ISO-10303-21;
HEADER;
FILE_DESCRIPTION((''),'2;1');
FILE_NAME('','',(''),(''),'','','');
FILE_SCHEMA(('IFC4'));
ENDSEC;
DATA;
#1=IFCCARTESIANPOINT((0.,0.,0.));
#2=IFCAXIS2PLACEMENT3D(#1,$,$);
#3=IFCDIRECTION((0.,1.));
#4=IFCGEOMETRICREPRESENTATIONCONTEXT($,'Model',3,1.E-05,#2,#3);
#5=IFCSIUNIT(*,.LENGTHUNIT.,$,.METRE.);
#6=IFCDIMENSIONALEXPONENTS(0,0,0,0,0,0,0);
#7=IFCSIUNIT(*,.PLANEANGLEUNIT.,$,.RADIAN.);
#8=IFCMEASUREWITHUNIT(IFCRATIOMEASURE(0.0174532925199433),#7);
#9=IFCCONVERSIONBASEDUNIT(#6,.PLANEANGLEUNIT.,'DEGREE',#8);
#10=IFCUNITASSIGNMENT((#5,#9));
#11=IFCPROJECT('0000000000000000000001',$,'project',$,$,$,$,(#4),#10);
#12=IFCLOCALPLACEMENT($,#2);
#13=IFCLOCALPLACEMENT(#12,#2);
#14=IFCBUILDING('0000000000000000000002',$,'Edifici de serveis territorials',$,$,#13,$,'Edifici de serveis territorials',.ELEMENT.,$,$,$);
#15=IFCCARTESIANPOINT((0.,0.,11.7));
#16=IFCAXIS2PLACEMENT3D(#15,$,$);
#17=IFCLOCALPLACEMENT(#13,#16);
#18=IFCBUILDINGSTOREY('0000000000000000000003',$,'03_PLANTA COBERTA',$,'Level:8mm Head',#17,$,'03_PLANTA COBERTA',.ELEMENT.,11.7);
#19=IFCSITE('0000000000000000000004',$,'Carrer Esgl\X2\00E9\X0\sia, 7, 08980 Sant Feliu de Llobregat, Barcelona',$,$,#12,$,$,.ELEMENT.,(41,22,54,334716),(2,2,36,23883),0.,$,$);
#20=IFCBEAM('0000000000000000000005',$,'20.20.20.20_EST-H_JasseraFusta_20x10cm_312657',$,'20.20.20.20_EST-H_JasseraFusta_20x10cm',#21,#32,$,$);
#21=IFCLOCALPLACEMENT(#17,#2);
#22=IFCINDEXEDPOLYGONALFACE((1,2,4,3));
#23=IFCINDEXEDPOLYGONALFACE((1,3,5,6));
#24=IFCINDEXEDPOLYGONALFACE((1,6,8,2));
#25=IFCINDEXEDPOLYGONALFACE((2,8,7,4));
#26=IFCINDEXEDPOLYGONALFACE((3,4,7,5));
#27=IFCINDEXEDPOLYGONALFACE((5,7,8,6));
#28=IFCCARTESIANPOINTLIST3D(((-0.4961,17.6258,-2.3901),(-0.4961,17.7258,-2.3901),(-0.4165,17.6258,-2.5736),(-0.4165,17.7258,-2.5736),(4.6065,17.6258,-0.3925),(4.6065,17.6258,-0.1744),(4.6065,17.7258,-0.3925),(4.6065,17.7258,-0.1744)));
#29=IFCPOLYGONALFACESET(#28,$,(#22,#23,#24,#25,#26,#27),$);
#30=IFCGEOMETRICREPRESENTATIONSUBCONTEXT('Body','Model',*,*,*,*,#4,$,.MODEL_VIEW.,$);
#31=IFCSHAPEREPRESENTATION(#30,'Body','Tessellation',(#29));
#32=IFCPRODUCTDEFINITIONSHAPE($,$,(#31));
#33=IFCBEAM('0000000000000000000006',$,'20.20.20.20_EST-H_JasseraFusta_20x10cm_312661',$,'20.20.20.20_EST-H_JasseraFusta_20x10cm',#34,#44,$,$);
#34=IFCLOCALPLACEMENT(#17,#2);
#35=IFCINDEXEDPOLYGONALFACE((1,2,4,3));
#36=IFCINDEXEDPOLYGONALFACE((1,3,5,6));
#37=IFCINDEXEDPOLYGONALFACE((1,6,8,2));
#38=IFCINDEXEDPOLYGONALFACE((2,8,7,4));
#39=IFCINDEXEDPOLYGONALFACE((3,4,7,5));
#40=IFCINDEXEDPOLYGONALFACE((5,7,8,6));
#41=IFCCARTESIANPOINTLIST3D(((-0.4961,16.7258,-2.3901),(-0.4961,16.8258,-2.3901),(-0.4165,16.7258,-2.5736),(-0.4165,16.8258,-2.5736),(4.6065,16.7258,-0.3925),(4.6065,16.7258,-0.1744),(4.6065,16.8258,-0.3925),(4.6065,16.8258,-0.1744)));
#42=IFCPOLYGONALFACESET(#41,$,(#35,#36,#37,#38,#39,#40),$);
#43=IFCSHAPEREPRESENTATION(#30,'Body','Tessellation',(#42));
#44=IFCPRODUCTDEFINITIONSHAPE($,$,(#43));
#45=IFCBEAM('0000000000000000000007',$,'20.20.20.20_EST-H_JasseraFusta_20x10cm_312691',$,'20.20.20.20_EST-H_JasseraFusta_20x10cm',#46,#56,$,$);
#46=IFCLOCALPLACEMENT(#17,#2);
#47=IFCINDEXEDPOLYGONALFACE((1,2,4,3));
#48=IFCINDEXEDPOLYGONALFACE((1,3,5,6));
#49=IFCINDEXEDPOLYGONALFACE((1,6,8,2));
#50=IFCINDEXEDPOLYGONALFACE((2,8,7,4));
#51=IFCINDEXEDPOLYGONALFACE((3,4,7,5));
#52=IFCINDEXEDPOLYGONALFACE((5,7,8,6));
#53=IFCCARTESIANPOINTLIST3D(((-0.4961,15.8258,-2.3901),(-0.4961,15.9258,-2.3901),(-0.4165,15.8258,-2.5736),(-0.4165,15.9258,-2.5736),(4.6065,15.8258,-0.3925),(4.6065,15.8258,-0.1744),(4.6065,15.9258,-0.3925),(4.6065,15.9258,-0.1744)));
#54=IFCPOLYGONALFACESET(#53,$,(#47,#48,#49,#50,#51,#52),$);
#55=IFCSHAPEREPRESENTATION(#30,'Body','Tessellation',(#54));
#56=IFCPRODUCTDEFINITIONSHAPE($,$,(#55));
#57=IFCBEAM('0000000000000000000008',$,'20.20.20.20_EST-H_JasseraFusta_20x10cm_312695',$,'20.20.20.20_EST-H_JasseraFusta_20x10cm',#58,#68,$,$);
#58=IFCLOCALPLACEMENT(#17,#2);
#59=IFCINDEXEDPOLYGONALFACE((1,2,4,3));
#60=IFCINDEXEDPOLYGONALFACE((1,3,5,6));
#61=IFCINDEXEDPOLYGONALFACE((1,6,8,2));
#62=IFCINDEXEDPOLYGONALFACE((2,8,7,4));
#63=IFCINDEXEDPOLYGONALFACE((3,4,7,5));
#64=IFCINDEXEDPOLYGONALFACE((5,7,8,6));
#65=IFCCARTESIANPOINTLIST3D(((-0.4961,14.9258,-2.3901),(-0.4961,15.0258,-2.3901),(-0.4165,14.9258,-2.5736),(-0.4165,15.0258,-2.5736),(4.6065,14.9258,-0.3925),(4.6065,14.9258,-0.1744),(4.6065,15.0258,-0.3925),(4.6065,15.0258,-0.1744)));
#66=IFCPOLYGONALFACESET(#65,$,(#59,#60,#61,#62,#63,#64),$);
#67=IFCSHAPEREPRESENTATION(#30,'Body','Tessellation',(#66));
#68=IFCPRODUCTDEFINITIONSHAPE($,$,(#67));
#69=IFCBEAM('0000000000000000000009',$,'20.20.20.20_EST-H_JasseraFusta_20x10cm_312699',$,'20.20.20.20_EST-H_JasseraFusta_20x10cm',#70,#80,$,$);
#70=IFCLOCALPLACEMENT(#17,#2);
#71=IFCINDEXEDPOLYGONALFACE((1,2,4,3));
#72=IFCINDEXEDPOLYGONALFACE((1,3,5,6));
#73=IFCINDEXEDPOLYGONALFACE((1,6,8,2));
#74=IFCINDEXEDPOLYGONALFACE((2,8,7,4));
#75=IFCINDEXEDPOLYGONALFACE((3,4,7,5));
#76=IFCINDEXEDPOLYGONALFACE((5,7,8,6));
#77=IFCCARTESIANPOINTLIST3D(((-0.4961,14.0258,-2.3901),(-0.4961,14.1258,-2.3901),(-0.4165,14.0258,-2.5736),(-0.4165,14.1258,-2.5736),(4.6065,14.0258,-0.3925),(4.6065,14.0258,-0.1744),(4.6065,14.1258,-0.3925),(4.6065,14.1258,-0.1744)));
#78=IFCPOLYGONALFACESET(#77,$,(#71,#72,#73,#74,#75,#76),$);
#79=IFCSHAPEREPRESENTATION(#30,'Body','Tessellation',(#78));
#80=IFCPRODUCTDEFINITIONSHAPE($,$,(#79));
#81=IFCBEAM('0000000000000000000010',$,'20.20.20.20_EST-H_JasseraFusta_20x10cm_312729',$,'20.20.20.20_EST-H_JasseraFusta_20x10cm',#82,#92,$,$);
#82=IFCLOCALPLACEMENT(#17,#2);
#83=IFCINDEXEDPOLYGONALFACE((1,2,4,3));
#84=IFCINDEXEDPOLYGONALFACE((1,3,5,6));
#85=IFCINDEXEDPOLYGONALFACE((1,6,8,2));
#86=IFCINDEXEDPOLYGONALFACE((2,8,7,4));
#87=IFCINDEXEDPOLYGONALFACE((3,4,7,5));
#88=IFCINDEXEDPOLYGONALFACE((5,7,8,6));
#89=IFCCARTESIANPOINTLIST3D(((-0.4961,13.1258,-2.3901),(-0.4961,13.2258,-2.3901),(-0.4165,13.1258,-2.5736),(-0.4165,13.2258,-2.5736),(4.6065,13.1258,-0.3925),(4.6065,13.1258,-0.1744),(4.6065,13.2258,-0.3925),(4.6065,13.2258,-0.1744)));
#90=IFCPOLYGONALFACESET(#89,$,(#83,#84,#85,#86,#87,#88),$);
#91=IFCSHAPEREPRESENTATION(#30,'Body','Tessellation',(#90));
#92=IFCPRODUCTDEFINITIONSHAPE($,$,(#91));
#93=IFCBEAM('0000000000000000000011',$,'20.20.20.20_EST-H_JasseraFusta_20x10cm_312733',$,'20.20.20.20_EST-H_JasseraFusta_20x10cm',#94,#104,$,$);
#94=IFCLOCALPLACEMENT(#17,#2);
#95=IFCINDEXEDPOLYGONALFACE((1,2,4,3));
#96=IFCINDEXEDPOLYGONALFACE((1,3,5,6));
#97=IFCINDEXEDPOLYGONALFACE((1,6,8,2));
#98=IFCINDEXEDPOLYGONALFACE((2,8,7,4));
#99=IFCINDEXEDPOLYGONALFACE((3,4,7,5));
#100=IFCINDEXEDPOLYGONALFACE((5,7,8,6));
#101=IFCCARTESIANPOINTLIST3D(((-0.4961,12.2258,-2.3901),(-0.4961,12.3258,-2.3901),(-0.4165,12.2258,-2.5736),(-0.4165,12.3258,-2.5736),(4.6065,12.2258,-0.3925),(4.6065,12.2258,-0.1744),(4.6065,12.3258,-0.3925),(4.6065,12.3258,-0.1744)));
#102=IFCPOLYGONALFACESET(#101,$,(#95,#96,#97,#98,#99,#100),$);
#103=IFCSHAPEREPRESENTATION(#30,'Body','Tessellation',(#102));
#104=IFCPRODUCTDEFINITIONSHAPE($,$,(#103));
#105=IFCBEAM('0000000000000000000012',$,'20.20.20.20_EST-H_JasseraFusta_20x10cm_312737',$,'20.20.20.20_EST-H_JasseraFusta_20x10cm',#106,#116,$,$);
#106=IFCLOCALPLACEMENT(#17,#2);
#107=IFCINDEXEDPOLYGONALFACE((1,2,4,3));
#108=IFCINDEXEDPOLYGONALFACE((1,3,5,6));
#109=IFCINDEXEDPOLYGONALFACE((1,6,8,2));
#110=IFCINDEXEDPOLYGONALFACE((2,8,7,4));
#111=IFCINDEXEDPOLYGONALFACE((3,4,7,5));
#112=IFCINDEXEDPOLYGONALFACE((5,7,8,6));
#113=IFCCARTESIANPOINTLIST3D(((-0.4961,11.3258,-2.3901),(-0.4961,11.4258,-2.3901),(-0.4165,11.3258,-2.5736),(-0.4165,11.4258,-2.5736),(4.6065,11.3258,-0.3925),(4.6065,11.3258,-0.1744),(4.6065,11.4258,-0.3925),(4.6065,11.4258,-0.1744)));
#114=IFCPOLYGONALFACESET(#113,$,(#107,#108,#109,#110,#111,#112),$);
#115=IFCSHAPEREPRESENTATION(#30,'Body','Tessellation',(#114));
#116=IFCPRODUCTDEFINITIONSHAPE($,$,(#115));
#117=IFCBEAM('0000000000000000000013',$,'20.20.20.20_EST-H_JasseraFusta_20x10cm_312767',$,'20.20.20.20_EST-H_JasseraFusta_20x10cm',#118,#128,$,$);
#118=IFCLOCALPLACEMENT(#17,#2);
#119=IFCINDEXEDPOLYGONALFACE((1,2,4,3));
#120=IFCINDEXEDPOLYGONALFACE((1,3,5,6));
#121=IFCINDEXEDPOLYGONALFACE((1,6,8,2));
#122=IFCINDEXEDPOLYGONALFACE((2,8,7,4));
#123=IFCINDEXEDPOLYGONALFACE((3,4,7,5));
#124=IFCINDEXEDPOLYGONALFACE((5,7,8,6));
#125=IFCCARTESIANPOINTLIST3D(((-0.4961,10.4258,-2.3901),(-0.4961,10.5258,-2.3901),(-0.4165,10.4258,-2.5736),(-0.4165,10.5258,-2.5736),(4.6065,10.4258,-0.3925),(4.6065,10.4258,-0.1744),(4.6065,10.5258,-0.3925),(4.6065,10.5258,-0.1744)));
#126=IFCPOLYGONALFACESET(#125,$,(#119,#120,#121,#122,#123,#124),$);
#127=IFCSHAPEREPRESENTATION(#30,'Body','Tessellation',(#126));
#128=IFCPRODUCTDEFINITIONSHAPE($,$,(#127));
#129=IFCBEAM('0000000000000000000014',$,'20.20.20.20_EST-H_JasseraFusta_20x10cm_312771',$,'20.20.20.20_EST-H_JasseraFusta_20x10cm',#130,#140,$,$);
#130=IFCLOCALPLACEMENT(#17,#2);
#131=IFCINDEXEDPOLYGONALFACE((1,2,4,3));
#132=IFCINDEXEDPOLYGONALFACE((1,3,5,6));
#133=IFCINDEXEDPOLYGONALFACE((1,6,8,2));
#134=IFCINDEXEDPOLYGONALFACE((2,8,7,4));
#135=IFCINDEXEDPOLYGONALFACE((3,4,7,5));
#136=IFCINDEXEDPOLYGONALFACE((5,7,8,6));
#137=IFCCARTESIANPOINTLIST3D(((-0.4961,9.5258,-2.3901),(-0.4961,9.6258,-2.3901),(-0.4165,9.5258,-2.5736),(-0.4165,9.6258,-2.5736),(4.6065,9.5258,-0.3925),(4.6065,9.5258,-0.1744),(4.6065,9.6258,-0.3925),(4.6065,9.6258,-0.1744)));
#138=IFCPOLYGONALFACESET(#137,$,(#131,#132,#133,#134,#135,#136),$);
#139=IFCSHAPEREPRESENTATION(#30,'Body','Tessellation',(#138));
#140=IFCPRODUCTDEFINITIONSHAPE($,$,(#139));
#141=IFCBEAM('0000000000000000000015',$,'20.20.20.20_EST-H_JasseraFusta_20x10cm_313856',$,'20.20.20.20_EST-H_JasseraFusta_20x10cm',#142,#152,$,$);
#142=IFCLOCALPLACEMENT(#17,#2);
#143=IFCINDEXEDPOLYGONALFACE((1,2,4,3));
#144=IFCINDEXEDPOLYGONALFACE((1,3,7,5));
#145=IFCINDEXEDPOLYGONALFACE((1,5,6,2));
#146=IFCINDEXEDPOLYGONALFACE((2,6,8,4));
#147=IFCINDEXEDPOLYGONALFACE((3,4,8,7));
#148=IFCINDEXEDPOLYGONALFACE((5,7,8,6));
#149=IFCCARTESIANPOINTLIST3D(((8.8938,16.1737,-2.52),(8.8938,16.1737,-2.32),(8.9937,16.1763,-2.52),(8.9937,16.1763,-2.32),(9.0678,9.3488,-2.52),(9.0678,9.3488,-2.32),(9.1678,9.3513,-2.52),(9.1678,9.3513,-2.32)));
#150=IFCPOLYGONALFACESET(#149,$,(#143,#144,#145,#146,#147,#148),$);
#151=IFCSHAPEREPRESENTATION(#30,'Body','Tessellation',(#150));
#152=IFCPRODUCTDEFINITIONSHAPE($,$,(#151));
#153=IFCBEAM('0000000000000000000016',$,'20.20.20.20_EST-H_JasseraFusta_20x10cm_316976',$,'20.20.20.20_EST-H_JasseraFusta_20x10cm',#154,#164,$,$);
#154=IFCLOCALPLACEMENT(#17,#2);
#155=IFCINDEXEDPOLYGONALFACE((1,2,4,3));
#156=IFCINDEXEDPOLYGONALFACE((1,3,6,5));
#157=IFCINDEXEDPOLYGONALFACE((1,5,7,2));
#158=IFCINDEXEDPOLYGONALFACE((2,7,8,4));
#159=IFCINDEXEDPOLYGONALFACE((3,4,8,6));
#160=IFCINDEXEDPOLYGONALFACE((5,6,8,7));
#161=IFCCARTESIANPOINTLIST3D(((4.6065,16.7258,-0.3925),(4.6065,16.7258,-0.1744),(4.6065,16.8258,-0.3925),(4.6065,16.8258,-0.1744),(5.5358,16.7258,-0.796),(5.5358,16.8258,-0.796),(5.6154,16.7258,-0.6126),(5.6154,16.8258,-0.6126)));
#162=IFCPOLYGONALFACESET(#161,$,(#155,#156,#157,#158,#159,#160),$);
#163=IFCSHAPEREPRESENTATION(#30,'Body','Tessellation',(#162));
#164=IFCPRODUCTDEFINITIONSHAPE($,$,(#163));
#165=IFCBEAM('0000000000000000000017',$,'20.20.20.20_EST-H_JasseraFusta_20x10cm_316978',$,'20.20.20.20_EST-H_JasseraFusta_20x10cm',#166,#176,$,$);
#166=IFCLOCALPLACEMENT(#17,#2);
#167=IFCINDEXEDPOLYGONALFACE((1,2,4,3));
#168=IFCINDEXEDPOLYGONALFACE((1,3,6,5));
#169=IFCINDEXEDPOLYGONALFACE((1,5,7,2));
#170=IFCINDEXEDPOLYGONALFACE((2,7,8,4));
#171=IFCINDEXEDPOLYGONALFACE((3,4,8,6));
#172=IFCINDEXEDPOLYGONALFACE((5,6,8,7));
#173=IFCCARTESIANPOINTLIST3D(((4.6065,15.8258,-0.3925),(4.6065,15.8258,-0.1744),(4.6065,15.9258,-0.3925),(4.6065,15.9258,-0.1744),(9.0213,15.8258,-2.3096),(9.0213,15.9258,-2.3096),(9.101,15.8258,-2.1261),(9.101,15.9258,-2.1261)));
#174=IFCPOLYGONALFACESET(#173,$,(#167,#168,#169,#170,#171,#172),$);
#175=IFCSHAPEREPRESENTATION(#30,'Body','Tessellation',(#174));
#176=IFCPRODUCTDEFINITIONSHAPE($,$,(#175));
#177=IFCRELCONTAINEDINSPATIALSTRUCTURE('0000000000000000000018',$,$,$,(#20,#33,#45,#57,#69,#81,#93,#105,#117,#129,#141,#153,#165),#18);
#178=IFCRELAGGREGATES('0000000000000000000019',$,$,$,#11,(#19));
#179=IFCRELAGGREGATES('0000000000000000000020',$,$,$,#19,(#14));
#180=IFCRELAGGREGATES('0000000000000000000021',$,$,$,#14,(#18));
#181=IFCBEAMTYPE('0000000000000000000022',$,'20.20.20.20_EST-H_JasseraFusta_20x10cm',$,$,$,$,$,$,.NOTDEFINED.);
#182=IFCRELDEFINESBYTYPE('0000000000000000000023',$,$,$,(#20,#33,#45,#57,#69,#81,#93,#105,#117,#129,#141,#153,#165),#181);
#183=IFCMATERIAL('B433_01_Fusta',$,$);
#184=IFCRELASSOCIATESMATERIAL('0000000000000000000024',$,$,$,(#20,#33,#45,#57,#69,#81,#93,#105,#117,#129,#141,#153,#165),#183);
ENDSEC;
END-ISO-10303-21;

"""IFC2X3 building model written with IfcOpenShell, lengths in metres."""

from ifc_helpers import new_model, entity, si_unit, converted_unit, direction, frame, frame_2d, origin, place, context, subcontext, project, spatial, rectangle, extrude, clip, halfspace, material, type_object, element, save


model = new_model("IFC2X3")

# Units and contexts
model_context = context("Model", 3, precision=1e-05, world=origin(), true_north=direction((0.0, 1.0)))
body_context = subcontext(model_context, "Body", "Model", "MODEL_VIEW")
ifc_project = project(units=[si_unit("LENGTHUNIT", "METRE"), converted_unit("PLANEANGLEUNIT", "DEGREE", entity("IfcRatioMeasure", 0.0174532925199433), si_unit("PLANEANGLEUNIT", "RADIAN"), dimensions=[0, 0, 0, 0, 0, 0, 0])], contexts=[model_context])

# Site, building, storey
site_placement = place(None, origin())
site = spatial("IfcSite", under=ifc_project, at=site_placement, Name="Carrer Església, 7, 08980 Sant Feliu de Llobregat, Barcelona", CompositionType="ELEMENT", RefLatitude=(41, 22, 54, 334716), RefLongitude=(2, 2, 36, 23883), RefElevation=0.0)
building_placement = place(site_placement, origin())
building = spatial("IfcBuilding", under=site, at=building_placement, Name="Edifici de serveis territorials", LongName="Edifici de serveis territorials", CompositionType="ELEMENT")
storey_placement = place(building_placement, frame((0.0, 0.0, 11.7)))
storey = spatial("IfcBuildingStorey", under=building, at=storey_placement, Name="03_PLANTA COBERTA", ObjectType="Level:8mm Head", LongName="03_PLANTA COBERTA", CompositionType="ELEMENT", Elevation=11.7)

# Beams
ifc_material_1 = material(Name="B433_01_Fusta")
beam_type = type_object("IfcBeamType", Name="20.20.20.20_EST-H_JasseraFusta_20x10cm", PredefinedType="NOTDEFINED")
beam_1_placement = place(storey_placement, frame((4.6065, 17.6758, -0.1744), z_axis=(-0.3983, 0.0, 0.917255), x_axis=(-0.917255, 0.0, -0.3983)))
element("IfcBeam", 1, at=beam_1_placement, inside=storey, type_object=beam_type, material=ifc_material_1, Name="20.20.20.20_EST-H_JasseraFusta_20x10cm_312657", ObjectType="20.20.20.20_EST-H_JasseraFusta_20x10cm", context=body_context, shape_type="Clipping", body=[
    clip(extrude(rectangle(XDim=0.2, YDim=0.1, at=frame_2d((0.0, 0.0), x_axis=(1.0, 0.0))), frame((0.0, 0.0, -0.1), z_axis=(1.0, 0.0, 0.0), x_axis=(0.0, 0.0, -1.0)), (0.0, 0.0, 1.0), 5.5629), halfspace(frame((0.0868, 0.0, -0.2), z_axis=(-0.917255, 0.0, -0.3983), x_axis=(0.0, 1.0, 0.0)), False)),
])
beam_2_placement = place(storey_placement, frame((4.6065, 16.7758, -0.1744), z_axis=(-0.3983, 0.0, 0.917255), x_axis=(-0.917255, 0.0, -0.3983)))
element("IfcBeam", 2, at=beam_2_placement, inside=storey, type_object=beam_type, material=ifc_material_1, Name="20.20.20.20_EST-H_JasseraFusta_20x10cm_312661", ObjectType="20.20.20.20_EST-H_JasseraFusta_20x10cm", context=body_context, shape_type="Clipping", body=[
    clip(extrude(rectangle(XDim=0.2, YDim=0.1, at=frame_2d((0.0, 0.0), x_axis=(1.0, 0.0))), frame((0.0, 0.0, -0.1), z_axis=(1.0, 0.0, 0.0), x_axis=(0.0, 0.0, -1.0)), (0.0, 0.0, 1.0), 5.5629), halfspace(frame((0.0868, 0.0, -0.2), z_axis=(-0.917255, 0.0, -0.3983), x_axis=(0.0, 1.0, 0.0)), False)),
])
beam_3_placement = place(storey_placement, frame((4.6065, 15.8758, -0.1744), z_axis=(-0.3983, 0.0, 0.917255), x_axis=(-0.917255, 0.0, -0.3983)))
element("IfcBeam", 3, at=beam_3_placement, inside=storey, type_object=beam_type, material=ifc_material_1, Name="20.20.20.20_EST-H_JasseraFusta_20x10cm_312691", ObjectType="20.20.20.20_EST-H_JasseraFusta_20x10cm", context=body_context, shape_type="Clipping", body=[
    clip(extrude(rectangle(XDim=0.2, YDim=0.1, at=frame_2d((0.0, 0.0), x_axis=(1.0, 0.0))), frame((0.0, 0.0, -0.1), z_axis=(1.0, 0.0, 0.0), x_axis=(0.0, 0.0, -1.0)), (0.0, 0.0, 1.0), 5.5629), halfspace(frame((0.0868, 0.0, -0.2), z_axis=(-0.917255, 0.0, -0.3983), x_axis=(0.0, 1.0, 0.0)), False)),
])
beam_4_placement = place(storey_placement, frame((4.6065, 14.9758, -0.1744), z_axis=(-0.3983, 0.0, 0.917255), x_axis=(-0.917255, 0.0, -0.3983)))
element("IfcBeam", 4, at=beam_4_placement, inside=storey, type_object=beam_type, material=ifc_material_1, Name="20.20.20.20_EST-H_JasseraFusta_20x10cm_312695", ObjectType="20.20.20.20_EST-H_JasseraFusta_20x10cm", context=body_context, shape_type="Clipping", body=[
    clip(extrude(rectangle(XDim=0.2, YDim=0.1, at=frame_2d((0.0, 0.0), x_axis=(1.0, 0.0))), frame((0.0, 0.0, -0.1), z_axis=(1.0, 0.0, 0.0), x_axis=(0.0, 0.0, -1.0)), (0.0, 0.0, 1.0), 5.5629), halfspace(frame((0.0868, 0.0, -0.2), z_axis=(-0.917255, 0.0, -0.3983), x_axis=(0.0, 1.0, 0.0)), False)),
])
beam_5_placement = place(storey_placement, frame((4.6065, 14.0758, -0.1744), z_axis=(-0.3983, 0.0, 0.917255), x_axis=(-0.917255, 0.0, -0.3983)))
element("IfcBeam", 5, at=beam_5_placement, inside=storey, type_object=beam_type, material=ifc_material_1, Name="20.20.20.20_EST-H_JasseraFusta_20x10cm_312699", ObjectType="20.20.20.20_EST-H_JasseraFusta_20x10cm", context=body_context, shape_type="Clipping", body=[
    clip(extrude(rectangle(XDim=0.2, YDim=0.1, at=frame_2d((0.0, 0.0), x_axis=(1.0, 0.0))), frame((0.0, 0.0, -0.1), z_axis=(1.0, 0.0, 0.0), x_axis=(0.0, 0.0, -1.0)), (0.0, 0.0, 1.0), 5.5629), halfspace(frame((0.0868, 0.0, -0.2), z_axis=(-0.917255, 0.0, -0.3983), x_axis=(0.0, 1.0, 0.0)), False)),
])
beam_6_placement = place(storey_placement, frame((4.6065, 13.1758, -0.1744), z_axis=(-0.3983, 0.0, 0.917255), x_axis=(-0.917255, 0.0, -0.3983)))
element("IfcBeam", 6, at=beam_6_placement, inside=storey, type_object=beam_type, material=ifc_material_1, Name="20.20.20.20_EST-H_JasseraFusta_20x10cm_312729", ObjectType="20.20.20.20_EST-H_JasseraFusta_20x10cm", context=body_context, shape_type="Clipping", body=[
    clip(extrude(rectangle(XDim=0.2, YDim=0.1, at=frame_2d((0.0, 0.0), x_axis=(1.0, 0.0))), frame((0.0, 0.0, -0.1), z_axis=(1.0, 0.0, 0.0), x_axis=(0.0, 0.0, -1.0)), (0.0, 0.0, 1.0), 5.5629), halfspace(frame((0.0868, 0.0, -0.2), z_axis=(-0.917255, 0.0, -0.3983), x_axis=(0.0, 1.0, 0.0)), False)),
])
beam_7_placement = place(storey_placement, frame((4.6065, 12.2758, -0.1744), z_axis=(-0.3983, 0.0, 0.917255), x_axis=(-0.917255, 0.0, -0.3983)))
element("IfcBeam", 7, at=beam_7_placement, inside=storey, type_object=beam_type, material=ifc_material_1, Name="20.20.20.20_EST-H_JasseraFusta_20x10cm_312733", ObjectType="20.20.20.20_EST-H_JasseraFusta_20x10cm", context=body_context, shape_type="Clipping", body=[
    clip(extrude(rectangle(XDim=0.2, YDim=0.1, at=frame_2d((0.0, 0.0), x_axis=(1.0, 0.0))), frame((0.0, 0.0, -0.1), z_axis=(1.0, 0.0, 0.0), x_axis=(0.0, 0.0, -1.0)), (0.0, 0.0, 1.0), 5.5629), halfspace(frame((0.0868, 0.0, -0.2), z_axis=(-0.917255, 0.0, -0.3983), x_axis=(0.0, 1.0, 0.0)), False)),
])
beam_8_placement = place(storey_placement, frame((4.6065, 11.3758, -0.1744), z_axis=(-0.3983, 0.0, 0.917255), x_axis=(-0.917255, 0.0, -0.3983)))
element("IfcBeam", 8, at=beam_8_placement, inside=storey, type_object=beam_type, material=ifc_material_1, Name="20.20.20.20_EST-H_JasseraFusta_20x10cm_312737", ObjectType="20.20.20.20_EST-H_JasseraFusta_20x10cm", context=body_context, shape_type="Clipping", body=[
    clip(extrude(rectangle(XDim=0.2, YDim=0.1, at=frame_2d((0.0, 0.0), x_axis=(1.0, 0.0))), frame((0.0, 0.0, -0.1), z_axis=(1.0, 0.0, 0.0), x_axis=(0.0, 0.0, -1.0)), (0.0, 0.0, 1.0), 5.5629), halfspace(frame((0.0868, 0.0, -0.2), z_axis=(-0.917255, 0.0, -0.3983), x_axis=(0.0, 1.0, 0.0)), False)),
])
beam_9_placement = place(storey_placement, frame((4.6065, 10.4758, -0.1744), z_axis=(-0.3983, 0.0, 0.917255), x_axis=(-0.917255, 0.0, -0.3983)))
element("IfcBeam", 9, at=beam_9_placement, inside=storey, type_object=beam_type, material=ifc_material_1, Name="20.20.20.20_EST-H_JasseraFusta_20x10cm_312767", ObjectType="20.20.20.20_EST-H_JasseraFusta_20x10cm", context=body_context, shape_type="Clipping", body=[
    clip(extrude(rectangle(XDim=0.2, YDim=0.1, at=frame_2d((0.0, 0.0), x_axis=(1.0, 0.0))), frame((0.0, 0.0, -0.1), z_axis=(1.0, 0.0, 0.0), x_axis=(0.0, 0.0, -1.0)), (0.0, 0.0, 1.0), 5.5629), halfspace(frame((0.0868, 0.0, -0.2), z_axis=(-0.917255, 0.0, -0.3983), x_axis=(0.0, 1.0, 0.0)), False)),
])
beam_10_placement = place(storey_placement, frame((4.6065, 9.5758, -0.1744), z_axis=(-0.3983, 0.0, 0.917255), x_axis=(-0.917255, 0.0, -0.3983)))
element("IfcBeam", 10, at=beam_10_placement, inside=storey, type_object=beam_type, material=ifc_material_1, Name="20.20.20.20_EST-H_JasseraFusta_20x10cm_312771", ObjectType="20.20.20.20_EST-H_JasseraFusta_20x10cm", context=body_context, shape_type="Clipping", body=[
    clip(extrude(rectangle(XDim=0.2, YDim=0.1, at=frame_2d((0.0, 0.0), x_axis=(1.0, 0.0))), frame((0.0, 0.0, -0.1), z_axis=(1.0, 0.0, 0.0), x_axis=(0.0, 0.0, -1.0)), (0.0, 0.0, 1.0), 5.5629), halfspace(frame((0.0868, 0.0, -0.2), z_axis=(-0.917255, 0.0, -0.3983), x_axis=(0.0, 1.0, 0.0)), False)),
])
beam_11_placement = place(storey_placement, frame((9.1178, 9.3501, -2.0), z_axis=(0.0, 0.0, 1.0), x_axis=(-0.025497, 0.999675, 0.0)))
element("IfcBeam", 11, at=beam_11_placement, inside=storey, type_object=beam_type, material=ifc_material_1, Name="20.20.20.20_EST-H_JasseraFusta_20x10cm_313856", ObjectType="20.20.20.20_EST-H_JasseraFusta_20x10cm", context=body_context, shape_type="SweptSolid", body=[
    extrude(rectangle(XDim=0.2, YDim=0.1, at=frame_2d((0.0, 0.0), x_axis=(1.0, 0.0))), frame((0.0, 0.0, -0.42), z_axis=(1.0, 0.0, 0.0), x_axis=(0.0, 0.0, -1.0)), (0.0, 0.0, 1.0), 6.8272),
])
beam_12_placement = place(storey_placement, frame((4.6065, 16.7758, -0.1744), z_axis=(0.3983, 0.0, 0.917255), x_axis=(0.917255, 0.0, -0.3983)))
element("IfcBeam", 12, at=beam_12_placement, inside=storey, type_object=beam_type, material=ifc_material_1, Name="20.20.20.20_EST-H_JasseraFusta_20x10cm_316976", ObjectType="20.20.20.20_EST-H_JasseraFusta_20x10cm", context=body_context, shape_type="Clipping", body=[
    clip(extrude(rectangle(XDim=0.2, YDim=0.1, at=frame_2d((0.0, 0.0), x_axis=(1.0, 0.0))), frame((0.0, 0.0, -0.1), z_axis=(1.0, 0.0, 0.0), x_axis=(0.0, 0.0, -1.0)), (0.0, 0.0, 1.0), 1.1), halfspace(frame((0.0868, 0.0, -0.2), z_axis=(-0.917255, 0.0, -0.3983), x_axis=(0.0, 1.0, 0.0)), False)),
])
beam_13_placement = place(storey_placement, frame((4.6065, 15.8758, -0.1744), z_axis=(0.3983, 0.0, 0.917255), x_axis=(0.917255, 0.0, -0.3983)))
element("IfcBeam", 13, at=beam_13_placement, inside=storey, type_object=beam_type, material=ifc_material_1, Name="20.20.20.20_EST-H_JasseraFusta_20x10cm_316978", ObjectType="20.20.20.20_EST-H_JasseraFusta_20x10cm", context=body_context, shape_type="Clipping", body=[
    clip(extrude(rectangle(XDim=0.2, YDim=0.1, at=frame_2d((0.0, 0.0), x_axis=(1.0, 0.0))), frame((0.0, 0.0, -0.1), z_axis=(1.0, 0.0, 0.0), x_axis=(0.0, 0.0, -1.0)), (0.0, 0.0, 1.0), 4.9), halfspace(frame((0.0868, 0.0, -0.2), z_axis=(-0.917255, 0.0, -0.3983), x_axis=(0.0, 1.0, 0.0)), False)),
])

save(model, "model.ifc")
